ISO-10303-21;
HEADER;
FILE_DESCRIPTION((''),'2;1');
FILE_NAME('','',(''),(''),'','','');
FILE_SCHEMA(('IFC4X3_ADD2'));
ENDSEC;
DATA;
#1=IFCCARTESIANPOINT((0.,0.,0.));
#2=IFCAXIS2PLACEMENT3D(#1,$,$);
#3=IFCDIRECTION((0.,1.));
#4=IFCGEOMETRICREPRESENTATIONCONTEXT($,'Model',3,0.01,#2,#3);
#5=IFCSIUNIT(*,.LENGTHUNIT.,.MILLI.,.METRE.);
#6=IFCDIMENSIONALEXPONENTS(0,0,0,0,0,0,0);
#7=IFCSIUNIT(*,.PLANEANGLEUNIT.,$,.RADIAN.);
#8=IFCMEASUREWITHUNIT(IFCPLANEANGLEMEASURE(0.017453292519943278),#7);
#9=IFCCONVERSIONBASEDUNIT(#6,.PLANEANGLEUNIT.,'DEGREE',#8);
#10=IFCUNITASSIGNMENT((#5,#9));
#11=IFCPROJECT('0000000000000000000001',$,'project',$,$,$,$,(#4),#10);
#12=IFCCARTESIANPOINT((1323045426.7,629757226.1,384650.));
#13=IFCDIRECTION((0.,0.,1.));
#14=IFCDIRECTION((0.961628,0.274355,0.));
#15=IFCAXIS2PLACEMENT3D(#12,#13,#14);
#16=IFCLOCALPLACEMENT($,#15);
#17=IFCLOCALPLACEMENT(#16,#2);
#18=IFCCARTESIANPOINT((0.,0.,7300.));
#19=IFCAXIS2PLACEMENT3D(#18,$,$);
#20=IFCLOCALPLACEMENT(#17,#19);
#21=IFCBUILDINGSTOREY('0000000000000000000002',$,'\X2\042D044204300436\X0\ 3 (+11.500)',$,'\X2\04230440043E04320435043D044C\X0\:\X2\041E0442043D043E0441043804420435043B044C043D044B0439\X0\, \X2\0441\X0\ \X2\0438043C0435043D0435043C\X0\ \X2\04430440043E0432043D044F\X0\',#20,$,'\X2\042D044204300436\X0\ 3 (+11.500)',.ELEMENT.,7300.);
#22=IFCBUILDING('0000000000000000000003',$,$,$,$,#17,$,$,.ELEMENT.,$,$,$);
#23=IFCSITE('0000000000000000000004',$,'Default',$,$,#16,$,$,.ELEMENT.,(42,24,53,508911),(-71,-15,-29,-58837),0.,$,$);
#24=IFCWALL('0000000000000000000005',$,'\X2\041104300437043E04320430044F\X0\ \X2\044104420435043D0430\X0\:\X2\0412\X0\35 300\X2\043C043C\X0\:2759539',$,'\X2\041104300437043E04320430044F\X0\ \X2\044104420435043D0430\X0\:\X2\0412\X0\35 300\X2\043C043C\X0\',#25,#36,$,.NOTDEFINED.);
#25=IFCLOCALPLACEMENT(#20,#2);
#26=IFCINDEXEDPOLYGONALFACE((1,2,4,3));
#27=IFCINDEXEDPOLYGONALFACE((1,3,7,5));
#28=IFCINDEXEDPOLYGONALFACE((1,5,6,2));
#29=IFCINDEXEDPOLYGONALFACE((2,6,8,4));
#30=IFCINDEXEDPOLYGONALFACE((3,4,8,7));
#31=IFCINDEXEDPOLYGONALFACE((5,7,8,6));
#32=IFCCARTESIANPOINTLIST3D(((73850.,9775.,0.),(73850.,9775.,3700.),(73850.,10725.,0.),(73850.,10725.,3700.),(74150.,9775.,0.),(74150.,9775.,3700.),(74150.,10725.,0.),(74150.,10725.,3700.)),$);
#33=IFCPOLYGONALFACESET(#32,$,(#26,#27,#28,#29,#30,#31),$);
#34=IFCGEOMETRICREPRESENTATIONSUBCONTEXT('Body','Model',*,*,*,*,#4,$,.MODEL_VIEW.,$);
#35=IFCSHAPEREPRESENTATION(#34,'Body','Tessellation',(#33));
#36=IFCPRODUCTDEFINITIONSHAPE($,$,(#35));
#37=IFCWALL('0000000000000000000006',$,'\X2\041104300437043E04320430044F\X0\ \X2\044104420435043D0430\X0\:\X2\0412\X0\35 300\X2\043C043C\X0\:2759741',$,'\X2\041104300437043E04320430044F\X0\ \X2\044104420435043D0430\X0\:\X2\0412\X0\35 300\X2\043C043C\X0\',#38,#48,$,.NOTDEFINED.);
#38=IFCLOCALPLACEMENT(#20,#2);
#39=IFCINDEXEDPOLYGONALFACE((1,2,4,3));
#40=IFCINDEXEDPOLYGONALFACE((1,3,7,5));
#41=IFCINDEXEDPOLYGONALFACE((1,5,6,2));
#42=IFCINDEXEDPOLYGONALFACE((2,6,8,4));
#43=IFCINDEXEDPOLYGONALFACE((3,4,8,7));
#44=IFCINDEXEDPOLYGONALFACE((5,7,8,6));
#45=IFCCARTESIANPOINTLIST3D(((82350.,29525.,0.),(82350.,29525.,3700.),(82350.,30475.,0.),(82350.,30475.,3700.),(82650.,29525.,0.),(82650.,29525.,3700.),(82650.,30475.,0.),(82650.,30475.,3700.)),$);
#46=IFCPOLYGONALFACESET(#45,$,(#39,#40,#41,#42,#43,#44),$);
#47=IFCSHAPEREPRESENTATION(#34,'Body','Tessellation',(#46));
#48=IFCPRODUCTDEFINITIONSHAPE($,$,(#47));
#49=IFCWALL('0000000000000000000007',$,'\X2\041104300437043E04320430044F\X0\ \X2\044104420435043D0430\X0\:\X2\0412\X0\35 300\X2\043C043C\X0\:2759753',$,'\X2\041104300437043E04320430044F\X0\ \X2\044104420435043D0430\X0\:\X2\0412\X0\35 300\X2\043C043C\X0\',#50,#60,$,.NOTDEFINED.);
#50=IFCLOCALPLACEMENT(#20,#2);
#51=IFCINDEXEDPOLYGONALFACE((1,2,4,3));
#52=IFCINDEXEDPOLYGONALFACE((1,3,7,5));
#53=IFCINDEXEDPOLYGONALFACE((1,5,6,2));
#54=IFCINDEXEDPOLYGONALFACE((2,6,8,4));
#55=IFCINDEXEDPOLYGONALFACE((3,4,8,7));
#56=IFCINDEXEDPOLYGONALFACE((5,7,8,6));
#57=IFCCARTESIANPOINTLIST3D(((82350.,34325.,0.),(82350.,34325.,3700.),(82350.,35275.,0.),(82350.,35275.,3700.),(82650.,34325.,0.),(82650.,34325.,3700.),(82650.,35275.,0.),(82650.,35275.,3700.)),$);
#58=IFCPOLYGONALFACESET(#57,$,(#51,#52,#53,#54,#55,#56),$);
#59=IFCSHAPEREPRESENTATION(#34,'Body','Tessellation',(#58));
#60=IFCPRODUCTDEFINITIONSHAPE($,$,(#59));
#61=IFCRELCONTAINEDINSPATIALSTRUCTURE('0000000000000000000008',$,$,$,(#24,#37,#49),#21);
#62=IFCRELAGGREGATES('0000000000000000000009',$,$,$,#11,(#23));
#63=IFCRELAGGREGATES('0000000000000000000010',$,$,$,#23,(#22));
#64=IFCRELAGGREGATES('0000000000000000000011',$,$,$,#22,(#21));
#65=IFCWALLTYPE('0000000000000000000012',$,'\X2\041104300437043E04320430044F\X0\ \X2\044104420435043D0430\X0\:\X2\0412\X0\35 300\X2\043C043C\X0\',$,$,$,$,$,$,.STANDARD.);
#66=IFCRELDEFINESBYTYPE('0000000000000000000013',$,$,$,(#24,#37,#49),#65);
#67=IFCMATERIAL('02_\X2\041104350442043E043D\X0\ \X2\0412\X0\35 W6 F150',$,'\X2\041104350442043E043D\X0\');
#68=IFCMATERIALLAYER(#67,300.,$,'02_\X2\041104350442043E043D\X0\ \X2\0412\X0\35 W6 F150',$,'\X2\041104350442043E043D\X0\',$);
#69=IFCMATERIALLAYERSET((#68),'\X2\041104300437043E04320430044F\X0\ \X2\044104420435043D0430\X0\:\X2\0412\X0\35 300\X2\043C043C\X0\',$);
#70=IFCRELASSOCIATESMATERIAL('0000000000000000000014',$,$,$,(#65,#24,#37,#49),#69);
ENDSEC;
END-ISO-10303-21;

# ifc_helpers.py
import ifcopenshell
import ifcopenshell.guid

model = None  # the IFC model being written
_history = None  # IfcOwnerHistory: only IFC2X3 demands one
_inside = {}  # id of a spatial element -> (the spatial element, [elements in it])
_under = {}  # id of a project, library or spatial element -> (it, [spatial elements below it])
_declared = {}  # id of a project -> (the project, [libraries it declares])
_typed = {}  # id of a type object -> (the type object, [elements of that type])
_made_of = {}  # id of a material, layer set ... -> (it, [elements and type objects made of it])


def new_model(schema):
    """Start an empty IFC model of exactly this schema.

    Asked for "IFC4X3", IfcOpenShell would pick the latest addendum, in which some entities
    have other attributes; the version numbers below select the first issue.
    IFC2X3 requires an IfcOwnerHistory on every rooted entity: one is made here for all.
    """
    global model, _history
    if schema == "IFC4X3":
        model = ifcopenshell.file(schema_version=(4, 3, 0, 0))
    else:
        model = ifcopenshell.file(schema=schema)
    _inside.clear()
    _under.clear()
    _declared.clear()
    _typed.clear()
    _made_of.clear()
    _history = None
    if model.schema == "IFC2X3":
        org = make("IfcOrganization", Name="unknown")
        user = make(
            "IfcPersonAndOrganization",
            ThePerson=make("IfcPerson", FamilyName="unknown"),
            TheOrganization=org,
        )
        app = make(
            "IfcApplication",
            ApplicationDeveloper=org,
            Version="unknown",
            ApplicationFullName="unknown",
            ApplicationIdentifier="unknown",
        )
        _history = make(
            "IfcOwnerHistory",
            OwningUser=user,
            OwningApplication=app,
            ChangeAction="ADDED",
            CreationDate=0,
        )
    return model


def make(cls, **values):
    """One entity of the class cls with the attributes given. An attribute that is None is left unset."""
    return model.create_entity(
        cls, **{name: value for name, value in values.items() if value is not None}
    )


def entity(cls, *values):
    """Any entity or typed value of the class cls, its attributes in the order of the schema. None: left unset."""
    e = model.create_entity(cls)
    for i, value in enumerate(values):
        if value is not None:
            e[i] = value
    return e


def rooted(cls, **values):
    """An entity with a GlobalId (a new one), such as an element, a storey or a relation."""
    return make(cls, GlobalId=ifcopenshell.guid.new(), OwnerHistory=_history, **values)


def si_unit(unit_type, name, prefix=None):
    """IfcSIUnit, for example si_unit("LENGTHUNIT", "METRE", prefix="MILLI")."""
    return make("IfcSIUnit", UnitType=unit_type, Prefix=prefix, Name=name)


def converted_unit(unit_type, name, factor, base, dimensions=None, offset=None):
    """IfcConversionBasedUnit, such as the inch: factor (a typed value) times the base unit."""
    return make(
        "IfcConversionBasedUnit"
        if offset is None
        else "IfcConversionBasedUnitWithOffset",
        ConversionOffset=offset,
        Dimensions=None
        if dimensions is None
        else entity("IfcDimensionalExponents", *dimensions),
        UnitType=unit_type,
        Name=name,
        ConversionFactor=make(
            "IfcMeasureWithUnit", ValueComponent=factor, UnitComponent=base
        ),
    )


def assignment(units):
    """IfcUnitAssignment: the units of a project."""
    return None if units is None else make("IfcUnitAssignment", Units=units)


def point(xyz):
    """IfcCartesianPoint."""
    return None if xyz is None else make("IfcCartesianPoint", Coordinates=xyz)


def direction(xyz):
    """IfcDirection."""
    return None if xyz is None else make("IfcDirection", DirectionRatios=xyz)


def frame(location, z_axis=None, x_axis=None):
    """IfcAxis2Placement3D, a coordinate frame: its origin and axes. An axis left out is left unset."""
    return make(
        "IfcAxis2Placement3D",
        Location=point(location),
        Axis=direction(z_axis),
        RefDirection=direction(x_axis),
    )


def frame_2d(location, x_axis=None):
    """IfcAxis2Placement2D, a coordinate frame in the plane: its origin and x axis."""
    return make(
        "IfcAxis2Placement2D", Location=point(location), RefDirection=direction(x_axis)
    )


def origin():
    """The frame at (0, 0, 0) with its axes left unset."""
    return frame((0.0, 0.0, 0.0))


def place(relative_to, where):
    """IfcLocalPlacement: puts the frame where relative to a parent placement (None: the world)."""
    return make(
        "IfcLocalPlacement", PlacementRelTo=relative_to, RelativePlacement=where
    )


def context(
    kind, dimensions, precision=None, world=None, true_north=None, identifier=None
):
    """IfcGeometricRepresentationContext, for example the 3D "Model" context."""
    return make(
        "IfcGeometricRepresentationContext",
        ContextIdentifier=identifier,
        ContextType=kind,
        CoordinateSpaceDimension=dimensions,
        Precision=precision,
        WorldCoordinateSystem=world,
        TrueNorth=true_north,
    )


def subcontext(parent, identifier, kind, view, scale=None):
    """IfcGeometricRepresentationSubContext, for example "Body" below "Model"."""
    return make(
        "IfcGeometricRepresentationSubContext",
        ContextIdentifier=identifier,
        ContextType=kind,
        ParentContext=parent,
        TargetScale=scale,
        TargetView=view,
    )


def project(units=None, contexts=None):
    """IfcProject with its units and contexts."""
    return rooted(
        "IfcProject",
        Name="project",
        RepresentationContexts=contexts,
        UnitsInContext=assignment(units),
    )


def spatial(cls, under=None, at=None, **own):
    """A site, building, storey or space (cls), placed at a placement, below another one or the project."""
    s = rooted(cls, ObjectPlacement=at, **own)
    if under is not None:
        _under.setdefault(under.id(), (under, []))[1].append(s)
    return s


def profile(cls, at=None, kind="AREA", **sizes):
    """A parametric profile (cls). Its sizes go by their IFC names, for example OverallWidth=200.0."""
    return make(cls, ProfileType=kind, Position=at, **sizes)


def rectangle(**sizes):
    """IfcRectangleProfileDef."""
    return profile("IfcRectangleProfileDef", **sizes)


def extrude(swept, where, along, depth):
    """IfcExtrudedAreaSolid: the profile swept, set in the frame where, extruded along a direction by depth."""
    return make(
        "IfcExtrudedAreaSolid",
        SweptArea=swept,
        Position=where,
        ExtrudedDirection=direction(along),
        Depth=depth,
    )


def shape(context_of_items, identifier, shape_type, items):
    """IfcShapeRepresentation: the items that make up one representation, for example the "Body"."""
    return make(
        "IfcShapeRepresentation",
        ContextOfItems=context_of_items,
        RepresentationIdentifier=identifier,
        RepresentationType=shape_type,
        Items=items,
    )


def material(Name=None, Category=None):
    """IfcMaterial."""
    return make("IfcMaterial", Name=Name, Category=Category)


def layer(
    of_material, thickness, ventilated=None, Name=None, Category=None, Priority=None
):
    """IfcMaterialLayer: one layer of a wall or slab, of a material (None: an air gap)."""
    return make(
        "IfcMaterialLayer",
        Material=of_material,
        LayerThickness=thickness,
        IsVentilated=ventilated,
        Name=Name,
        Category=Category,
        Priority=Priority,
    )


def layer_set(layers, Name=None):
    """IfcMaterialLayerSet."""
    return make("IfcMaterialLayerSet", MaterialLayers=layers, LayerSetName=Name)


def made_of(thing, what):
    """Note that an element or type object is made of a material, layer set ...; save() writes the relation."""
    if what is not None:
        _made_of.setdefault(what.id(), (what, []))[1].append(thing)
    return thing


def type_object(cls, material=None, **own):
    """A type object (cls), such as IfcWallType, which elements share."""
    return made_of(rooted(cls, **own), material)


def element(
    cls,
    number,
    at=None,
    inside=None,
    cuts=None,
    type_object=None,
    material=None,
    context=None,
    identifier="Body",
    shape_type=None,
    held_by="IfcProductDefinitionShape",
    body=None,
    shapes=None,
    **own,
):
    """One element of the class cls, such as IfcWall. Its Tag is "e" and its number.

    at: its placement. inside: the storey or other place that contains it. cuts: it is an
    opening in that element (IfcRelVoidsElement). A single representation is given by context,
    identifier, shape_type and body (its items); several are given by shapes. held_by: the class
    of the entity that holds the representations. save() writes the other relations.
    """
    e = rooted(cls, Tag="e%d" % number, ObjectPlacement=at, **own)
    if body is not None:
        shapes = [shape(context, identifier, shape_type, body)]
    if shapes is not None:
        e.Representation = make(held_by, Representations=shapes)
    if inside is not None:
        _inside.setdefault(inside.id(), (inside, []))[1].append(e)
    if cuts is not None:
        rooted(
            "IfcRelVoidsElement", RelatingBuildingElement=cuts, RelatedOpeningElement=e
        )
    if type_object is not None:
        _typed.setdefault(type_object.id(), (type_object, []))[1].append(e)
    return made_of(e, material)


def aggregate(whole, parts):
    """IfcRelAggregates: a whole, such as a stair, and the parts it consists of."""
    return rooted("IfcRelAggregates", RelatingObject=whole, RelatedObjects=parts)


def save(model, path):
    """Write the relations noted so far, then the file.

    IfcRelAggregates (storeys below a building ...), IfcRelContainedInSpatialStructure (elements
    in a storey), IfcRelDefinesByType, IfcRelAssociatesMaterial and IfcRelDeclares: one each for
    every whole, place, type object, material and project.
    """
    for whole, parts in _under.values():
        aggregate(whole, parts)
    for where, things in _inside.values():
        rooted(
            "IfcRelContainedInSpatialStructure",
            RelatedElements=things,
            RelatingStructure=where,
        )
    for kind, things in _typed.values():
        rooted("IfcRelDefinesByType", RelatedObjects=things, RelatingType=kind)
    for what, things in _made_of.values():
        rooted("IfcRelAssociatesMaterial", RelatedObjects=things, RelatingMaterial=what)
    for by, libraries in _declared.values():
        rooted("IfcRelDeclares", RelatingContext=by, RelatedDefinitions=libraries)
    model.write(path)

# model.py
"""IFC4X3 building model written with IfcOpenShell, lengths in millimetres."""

from ifc_helpers import new_model, entity, si_unit, converted_unit, direction, frame, frame_2d, origin, place, context, subcontext, project, spatial, rectangle, extrude, material, layer, layer_set, type_object, element, save


model = new_model("IFC4X3")

# Units and contexts
model_context = context("Model", 3, precision=0.01, world=origin(), true_north=direction((0.0, 1.0)))
body_context = subcontext(model_context, "Body", "Model", "MODEL_VIEW")
ifc_project = project(units=[si_unit("LENGTHUNIT", "METRE", prefix="MILLI"), converted_unit("PLANEANGLEUNIT", "DEGREE", entity("IfcPlaneAngleMeasure", 0.017453292519943278), si_unit("PLANEANGLEUNIT", "RADIAN"), dimensions=[0, 0, 0, 0, 0, 0, 0])], contexts=[model_context])

# Site, building, storey
site_placement = place(None, frame((1323045426.7, 629757226.1, 384650.0), z_axis=(0.0, 0.0, 1.0), x_axis=(0.961628, 0.274355, 0.0)))
site = spatial("IfcSite", under=ifc_project, at=site_placement, Name="Default", CompositionType="ELEMENT", RefLatitude=(42, 24, 53, 508911), RefLongitude=(-71, -15, -29, -58837), RefElevation=0.0)
building_placement = place(site_placement, origin())
building = spatial("IfcBuilding", under=site, at=building_placement, CompositionType="ELEMENT")
storey_placement = place(building_placement, frame((0.0, 0.0, 7300.0)))
storey = spatial("IfcBuildingStorey", under=building, at=storey_placement, Name="Этаж 3 (+11.500)", ObjectType="Уровень:Относительный, с именем уровня", LongName="Этаж 3 (+11.500)", CompositionType="ELEMENT", Elevation=7300.0)

# Shared definitions
ifc_material = material(Name="02_Бетон В35 W6 F150", Category="Бетон")

# Walls
ifc_layer_1 = layer(ifc_material, 300.0, Name="02_Бетон В35 W6 F150", Category="Бетон")
ifc_layer_set_1 = layer_set([ifc_layer_1], Name="Базовая стена:В35 300мм")
wall_type_1 = type_object("IfcWallType", Name="Базовая стена:В35 300мм", PredefinedType="STANDARD", material=ifc_layer_set_1)
for number, where, z_axis, x_axis, name in (
    (1, (74000.0, 9775.0, 0.0), (0.0, 0.0, 1.0), (0.0, 1.0, 0.0), "Базовая стена:В35 300мм:2759539"),
    (2, (82500.0, 29525.0, 0.0), (0.0, 0.0, 1.0), (0.0, 1.0, 0.0), "Базовая стена:В35 300мм:2759741"),
    (3, (82500.0, 34325.0, 0.0), (0.0, 0.0, 1.0), (0.0, 1.0, 0.0), "Базовая стена:В35 300мм:2759753"),
):
    element("IfcWall", number, at=place(storey_placement, frame(where, z_axis=z_axis, x_axis=x_axis)), inside=storey, type_object=wall_type_1, material=ifc_layer_set_1, Name=name, ObjectType="Базовая стена:В35 300мм", PredefinedType="NOTDEFINED", context=body_context, shape_type="SweptSolid", body=[
        extrude(rectangle(XDim=950.0, YDim=300.0, at=frame_2d((475.0, 0.0), x_axis=(-1.0, 0.0))), origin(), (0.0, 0.0, 1.0), 3700.0),
    ])

save(model, "model.ifc")
